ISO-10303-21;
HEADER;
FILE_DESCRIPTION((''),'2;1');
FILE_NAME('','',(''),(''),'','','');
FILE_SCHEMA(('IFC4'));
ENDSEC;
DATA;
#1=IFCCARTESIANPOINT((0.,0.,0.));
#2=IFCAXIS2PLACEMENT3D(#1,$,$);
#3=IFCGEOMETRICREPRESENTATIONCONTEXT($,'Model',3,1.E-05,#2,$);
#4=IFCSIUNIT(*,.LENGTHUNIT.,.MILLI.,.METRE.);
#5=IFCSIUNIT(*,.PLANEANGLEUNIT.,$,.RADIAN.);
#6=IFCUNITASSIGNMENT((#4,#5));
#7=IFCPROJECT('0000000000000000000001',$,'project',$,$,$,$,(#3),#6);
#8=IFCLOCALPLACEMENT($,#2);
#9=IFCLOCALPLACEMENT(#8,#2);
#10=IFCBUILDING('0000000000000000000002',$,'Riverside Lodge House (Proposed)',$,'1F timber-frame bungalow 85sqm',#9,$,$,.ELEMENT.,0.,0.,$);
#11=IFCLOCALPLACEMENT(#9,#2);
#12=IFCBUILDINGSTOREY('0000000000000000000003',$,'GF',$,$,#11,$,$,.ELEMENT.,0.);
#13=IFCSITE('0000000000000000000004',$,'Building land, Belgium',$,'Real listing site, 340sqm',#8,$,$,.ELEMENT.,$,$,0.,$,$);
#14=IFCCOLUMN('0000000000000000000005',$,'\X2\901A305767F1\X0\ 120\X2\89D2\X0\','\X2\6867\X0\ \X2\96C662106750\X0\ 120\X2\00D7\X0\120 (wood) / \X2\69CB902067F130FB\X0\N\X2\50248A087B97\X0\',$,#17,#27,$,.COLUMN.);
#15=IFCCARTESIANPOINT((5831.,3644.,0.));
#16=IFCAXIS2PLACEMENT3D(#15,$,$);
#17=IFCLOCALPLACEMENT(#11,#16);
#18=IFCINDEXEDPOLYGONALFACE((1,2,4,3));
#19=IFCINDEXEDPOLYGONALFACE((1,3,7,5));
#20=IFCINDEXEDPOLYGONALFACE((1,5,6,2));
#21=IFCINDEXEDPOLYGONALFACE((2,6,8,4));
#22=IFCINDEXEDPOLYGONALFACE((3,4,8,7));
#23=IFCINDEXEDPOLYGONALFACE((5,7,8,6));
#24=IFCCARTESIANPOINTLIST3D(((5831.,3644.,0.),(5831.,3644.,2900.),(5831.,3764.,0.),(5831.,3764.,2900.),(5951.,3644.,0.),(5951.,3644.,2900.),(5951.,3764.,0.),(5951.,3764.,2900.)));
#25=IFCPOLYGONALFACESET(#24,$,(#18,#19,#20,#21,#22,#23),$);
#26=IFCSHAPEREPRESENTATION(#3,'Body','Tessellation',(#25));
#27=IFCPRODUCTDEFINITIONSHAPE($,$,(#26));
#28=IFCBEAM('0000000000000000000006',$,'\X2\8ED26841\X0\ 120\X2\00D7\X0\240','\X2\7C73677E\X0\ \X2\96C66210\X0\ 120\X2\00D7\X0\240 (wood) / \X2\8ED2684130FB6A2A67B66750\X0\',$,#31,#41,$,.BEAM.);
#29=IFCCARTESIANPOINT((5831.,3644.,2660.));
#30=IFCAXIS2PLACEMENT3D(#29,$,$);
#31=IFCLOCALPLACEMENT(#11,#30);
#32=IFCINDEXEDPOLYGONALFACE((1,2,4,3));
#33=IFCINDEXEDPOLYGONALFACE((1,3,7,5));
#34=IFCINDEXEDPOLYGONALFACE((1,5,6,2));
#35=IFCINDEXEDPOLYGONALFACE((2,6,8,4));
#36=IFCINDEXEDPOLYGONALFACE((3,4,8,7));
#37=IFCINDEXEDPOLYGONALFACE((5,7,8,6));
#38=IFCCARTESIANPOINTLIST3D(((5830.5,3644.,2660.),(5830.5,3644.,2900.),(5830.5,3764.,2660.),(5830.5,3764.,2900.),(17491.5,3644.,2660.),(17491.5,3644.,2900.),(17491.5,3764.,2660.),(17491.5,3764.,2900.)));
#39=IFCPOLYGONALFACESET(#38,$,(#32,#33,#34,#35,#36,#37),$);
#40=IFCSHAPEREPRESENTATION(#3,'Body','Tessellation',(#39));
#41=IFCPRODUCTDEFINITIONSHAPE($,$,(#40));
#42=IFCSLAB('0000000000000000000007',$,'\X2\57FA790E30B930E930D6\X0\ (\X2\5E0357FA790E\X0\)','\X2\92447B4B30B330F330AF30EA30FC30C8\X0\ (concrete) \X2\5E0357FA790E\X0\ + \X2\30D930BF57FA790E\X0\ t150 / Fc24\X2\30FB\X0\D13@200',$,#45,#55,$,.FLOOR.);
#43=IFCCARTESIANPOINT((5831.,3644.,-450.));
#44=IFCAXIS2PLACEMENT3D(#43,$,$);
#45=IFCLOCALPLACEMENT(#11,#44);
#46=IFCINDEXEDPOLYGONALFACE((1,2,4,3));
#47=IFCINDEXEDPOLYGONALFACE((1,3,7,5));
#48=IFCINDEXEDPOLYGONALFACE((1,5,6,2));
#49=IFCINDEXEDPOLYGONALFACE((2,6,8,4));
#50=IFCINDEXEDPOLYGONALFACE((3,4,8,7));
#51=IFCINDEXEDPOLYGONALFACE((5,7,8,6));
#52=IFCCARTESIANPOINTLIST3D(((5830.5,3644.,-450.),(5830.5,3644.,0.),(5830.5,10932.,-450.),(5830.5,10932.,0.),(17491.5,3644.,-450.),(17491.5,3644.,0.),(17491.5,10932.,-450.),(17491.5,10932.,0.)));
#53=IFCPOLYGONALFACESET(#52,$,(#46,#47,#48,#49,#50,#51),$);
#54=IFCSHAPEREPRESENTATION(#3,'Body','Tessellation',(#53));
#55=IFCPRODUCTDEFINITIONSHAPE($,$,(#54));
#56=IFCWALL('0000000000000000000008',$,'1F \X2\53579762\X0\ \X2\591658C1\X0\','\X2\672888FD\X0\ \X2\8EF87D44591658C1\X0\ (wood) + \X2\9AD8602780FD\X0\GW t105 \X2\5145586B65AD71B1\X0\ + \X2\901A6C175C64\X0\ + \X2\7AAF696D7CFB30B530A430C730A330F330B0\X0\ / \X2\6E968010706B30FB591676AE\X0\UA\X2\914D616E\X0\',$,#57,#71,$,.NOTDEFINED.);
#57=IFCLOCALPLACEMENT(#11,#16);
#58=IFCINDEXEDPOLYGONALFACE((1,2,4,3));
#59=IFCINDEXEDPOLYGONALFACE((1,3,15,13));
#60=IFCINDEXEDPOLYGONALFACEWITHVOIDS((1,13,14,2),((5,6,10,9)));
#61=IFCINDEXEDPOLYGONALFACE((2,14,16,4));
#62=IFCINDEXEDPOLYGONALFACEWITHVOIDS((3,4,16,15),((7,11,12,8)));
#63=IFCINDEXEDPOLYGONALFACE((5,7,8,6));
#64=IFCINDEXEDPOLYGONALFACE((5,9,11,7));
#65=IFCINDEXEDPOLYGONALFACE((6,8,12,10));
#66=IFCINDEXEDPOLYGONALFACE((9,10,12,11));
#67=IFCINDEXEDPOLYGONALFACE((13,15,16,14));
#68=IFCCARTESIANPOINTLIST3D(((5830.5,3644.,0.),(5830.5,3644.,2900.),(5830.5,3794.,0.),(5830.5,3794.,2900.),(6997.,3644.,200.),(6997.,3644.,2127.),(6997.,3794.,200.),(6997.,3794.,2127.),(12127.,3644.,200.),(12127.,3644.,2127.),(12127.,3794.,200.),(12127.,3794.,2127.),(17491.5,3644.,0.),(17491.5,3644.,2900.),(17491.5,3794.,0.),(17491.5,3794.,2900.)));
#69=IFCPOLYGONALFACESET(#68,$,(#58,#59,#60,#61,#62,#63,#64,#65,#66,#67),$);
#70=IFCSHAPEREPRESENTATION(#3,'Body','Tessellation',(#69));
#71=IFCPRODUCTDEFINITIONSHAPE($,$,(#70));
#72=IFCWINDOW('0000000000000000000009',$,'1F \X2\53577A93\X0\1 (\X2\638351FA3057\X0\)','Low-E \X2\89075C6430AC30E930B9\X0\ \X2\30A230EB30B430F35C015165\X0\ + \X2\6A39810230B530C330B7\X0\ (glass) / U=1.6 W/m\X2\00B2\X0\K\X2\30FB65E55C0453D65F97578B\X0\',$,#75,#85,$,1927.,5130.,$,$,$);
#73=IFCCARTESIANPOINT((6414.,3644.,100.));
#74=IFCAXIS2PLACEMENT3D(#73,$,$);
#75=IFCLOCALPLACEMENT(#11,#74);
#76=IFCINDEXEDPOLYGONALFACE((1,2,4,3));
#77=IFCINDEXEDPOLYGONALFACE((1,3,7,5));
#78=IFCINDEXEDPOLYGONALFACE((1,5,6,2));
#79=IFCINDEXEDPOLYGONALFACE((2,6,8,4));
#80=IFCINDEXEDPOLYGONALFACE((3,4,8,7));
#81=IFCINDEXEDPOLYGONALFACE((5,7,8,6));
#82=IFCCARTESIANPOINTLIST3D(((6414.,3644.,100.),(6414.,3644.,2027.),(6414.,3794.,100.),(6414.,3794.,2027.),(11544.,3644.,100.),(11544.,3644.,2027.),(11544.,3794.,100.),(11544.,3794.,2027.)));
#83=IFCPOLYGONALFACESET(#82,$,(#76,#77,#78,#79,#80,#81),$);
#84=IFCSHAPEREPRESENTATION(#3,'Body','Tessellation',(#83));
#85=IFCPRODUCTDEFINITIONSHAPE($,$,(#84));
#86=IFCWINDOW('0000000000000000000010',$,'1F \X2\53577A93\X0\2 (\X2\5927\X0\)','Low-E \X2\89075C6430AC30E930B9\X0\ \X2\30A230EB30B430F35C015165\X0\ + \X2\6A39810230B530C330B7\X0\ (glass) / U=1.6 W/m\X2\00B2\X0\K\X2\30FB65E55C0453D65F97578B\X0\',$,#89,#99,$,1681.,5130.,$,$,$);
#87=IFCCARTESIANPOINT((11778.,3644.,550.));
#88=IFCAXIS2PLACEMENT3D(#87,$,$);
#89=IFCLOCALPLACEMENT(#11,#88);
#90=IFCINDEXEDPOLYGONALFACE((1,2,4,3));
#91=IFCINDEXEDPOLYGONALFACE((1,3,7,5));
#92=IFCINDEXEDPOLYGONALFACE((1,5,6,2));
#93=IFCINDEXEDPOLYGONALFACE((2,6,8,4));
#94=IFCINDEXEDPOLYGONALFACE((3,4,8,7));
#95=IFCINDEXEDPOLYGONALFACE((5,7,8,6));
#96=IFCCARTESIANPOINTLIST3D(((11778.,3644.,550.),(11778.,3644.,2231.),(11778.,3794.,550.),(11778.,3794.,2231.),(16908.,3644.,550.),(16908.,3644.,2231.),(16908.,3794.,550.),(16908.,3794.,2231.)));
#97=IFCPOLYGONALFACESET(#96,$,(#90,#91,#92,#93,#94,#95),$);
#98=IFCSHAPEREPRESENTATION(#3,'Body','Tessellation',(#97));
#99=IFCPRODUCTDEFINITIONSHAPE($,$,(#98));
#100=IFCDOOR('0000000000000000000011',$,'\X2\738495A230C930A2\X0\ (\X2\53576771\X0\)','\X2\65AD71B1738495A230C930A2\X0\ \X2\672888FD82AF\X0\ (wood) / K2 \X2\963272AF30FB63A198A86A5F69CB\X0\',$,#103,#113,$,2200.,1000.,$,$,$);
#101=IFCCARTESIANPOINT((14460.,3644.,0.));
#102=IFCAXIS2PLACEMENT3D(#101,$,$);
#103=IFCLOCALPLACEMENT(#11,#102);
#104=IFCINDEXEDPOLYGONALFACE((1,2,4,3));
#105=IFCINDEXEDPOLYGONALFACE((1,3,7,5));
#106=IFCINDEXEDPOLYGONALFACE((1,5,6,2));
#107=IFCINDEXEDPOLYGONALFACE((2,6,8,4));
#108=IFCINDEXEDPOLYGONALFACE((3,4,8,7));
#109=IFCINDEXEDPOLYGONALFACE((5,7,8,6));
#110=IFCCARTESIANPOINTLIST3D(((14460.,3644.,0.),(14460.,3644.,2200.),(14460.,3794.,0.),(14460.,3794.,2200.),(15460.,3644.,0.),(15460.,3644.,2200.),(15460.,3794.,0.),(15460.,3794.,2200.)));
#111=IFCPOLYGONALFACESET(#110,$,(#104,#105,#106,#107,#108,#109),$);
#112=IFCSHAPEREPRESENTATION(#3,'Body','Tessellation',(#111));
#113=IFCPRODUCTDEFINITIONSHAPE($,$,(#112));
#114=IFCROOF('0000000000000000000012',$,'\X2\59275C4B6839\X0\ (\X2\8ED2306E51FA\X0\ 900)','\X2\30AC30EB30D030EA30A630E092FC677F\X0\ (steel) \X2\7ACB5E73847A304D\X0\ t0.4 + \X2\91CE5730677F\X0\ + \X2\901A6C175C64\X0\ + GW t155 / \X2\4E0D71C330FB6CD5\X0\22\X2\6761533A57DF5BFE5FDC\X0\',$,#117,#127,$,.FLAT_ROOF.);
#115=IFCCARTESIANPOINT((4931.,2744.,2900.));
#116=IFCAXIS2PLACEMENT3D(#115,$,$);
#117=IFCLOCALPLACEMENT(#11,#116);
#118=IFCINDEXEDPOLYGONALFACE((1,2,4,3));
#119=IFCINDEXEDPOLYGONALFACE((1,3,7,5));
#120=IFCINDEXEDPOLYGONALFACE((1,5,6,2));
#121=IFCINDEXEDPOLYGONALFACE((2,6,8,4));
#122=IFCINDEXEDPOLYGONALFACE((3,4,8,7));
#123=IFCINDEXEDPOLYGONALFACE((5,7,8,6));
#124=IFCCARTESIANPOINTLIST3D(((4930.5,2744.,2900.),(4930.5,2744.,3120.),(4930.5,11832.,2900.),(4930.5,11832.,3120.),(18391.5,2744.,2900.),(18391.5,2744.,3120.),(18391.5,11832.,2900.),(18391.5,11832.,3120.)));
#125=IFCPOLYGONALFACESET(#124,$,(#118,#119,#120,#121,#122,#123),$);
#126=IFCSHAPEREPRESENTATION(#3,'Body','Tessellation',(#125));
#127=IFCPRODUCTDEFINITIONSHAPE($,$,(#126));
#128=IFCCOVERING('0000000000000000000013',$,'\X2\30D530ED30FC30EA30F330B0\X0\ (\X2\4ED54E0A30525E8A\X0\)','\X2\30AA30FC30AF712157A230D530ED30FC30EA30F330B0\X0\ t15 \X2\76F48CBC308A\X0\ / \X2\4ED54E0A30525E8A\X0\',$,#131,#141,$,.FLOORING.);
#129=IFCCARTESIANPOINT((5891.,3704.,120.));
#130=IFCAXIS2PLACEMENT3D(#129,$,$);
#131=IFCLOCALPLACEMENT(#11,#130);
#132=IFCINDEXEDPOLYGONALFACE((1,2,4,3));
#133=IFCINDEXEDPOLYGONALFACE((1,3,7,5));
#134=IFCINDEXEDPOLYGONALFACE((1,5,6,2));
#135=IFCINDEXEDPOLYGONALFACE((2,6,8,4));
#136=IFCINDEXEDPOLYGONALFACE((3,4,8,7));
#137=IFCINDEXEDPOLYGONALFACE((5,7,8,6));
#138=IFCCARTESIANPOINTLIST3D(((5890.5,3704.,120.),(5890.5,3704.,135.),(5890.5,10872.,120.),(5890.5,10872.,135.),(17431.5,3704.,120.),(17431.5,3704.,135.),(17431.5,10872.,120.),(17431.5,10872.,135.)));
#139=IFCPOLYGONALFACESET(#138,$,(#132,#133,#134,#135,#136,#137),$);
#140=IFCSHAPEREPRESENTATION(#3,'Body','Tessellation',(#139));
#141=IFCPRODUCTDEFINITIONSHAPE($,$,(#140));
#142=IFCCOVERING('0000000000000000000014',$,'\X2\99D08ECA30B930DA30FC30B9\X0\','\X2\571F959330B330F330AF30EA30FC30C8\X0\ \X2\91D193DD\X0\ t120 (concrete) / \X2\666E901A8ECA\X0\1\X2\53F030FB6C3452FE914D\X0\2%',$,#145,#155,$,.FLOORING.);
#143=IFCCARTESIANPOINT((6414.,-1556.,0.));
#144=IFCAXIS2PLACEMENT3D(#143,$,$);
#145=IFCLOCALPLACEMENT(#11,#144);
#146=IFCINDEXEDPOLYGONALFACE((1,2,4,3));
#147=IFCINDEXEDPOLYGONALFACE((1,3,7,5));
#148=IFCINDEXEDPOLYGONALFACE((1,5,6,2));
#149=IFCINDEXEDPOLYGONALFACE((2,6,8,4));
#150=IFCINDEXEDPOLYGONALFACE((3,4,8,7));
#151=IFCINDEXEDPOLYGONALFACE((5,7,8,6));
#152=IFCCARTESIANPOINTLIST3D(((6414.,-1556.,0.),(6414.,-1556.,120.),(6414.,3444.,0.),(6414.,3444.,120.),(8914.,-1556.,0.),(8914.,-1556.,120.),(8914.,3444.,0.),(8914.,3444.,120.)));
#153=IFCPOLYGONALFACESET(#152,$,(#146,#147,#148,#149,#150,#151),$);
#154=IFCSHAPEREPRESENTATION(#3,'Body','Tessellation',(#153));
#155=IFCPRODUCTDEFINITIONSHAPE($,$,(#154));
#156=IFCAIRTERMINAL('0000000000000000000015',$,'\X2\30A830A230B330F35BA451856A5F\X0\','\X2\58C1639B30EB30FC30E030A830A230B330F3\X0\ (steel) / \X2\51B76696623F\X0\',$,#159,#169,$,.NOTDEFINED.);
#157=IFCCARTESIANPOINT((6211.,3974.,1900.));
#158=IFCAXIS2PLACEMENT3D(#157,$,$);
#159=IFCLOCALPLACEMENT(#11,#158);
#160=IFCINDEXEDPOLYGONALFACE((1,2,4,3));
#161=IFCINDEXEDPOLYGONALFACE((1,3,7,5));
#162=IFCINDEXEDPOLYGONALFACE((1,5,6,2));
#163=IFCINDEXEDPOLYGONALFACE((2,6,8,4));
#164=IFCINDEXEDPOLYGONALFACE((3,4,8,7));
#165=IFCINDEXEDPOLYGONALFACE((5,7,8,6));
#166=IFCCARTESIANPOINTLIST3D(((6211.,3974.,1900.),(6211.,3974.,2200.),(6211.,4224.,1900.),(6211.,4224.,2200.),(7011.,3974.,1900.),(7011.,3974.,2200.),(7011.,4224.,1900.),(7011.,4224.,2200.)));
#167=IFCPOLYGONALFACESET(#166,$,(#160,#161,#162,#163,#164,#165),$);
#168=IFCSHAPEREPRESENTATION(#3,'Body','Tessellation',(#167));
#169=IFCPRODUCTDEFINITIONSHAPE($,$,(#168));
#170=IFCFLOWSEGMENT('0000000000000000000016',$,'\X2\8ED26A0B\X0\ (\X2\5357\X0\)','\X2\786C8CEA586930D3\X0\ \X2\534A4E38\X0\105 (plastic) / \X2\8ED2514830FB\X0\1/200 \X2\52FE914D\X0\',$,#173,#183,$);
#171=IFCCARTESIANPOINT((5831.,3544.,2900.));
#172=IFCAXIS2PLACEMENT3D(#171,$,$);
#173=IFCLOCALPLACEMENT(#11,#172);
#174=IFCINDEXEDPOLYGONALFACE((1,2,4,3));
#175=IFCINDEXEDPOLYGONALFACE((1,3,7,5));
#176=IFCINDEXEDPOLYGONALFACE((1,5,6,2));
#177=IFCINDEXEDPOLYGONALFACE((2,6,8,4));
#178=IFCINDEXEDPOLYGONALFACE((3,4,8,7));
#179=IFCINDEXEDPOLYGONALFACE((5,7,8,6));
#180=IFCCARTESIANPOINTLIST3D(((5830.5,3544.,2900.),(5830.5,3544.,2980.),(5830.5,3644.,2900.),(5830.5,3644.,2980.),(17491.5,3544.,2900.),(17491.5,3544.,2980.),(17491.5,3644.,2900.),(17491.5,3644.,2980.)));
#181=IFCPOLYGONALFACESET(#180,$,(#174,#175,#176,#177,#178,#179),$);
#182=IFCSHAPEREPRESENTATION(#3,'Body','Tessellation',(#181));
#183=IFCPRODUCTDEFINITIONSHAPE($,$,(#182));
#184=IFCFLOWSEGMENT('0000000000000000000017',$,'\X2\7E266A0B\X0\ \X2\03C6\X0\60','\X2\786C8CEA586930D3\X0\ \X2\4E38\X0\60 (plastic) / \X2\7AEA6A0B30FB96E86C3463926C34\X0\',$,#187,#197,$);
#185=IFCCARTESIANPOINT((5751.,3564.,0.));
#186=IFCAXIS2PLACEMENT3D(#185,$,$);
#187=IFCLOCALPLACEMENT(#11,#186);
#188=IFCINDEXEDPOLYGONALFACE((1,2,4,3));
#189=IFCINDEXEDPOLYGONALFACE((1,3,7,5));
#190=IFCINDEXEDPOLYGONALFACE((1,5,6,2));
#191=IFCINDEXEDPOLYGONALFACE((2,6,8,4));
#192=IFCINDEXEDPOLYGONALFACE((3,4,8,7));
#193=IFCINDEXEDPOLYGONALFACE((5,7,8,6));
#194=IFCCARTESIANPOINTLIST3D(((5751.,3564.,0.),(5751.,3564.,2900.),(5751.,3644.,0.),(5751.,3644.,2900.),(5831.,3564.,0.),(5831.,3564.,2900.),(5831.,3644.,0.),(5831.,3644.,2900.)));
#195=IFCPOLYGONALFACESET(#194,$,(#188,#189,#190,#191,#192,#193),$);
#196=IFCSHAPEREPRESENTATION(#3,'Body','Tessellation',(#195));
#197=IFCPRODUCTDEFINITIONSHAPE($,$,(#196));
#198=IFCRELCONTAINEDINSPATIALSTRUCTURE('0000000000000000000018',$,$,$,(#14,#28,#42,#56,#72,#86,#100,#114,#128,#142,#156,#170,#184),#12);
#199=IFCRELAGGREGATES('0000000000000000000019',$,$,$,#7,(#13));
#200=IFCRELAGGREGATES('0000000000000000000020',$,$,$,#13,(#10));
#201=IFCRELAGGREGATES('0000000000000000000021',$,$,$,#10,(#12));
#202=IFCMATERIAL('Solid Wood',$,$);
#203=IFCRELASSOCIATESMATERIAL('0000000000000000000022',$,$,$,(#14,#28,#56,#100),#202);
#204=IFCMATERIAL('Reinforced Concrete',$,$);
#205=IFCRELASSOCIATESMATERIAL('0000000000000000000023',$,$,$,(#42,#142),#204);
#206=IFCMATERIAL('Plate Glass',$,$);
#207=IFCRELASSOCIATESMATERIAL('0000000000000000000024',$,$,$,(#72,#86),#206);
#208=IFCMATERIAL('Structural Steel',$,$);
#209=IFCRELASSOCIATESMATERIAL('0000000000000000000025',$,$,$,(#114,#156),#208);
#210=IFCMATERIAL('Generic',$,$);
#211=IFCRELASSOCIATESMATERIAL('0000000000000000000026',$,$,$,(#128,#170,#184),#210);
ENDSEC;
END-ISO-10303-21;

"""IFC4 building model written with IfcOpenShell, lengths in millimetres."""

from ifc_helpers import new_model, si_unit, frame, frame_2d, origin, place, context, project, spatial, rectangle, extrude, material, element, fill, save


model = new_model("IFC4")

# Units and contexts
model_context = context("Model", 3, precision=1e-05, world=origin())
ifc_project = project(units=[si_unit("LENGTHUNIT", "METRE", prefix="MILLI"), si_unit("PLANEANGLEUNIT", "RADIAN")], contexts=[model_context])

# Site, building, storey
site_placement = place(None, origin())
site = spatial("IfcSite", under=ifc_project, at=site_placement, Name="Building land, Belgium", ObjectType="Real listing site, 340sqm", CompositionType="ELEMENT", RefElevation=0.0)
building_placement = place(site_placement, origin())
building = spatial("IfcBuilding", under=site, at=building_placement, Name="Riverside Lodge House (Proposed)", ObjectType="1F timber-frame bungalow 85sqm", CompositionType="ELEMENT", ElevationOfRefHeight=0.0, ElevationOfTerrain=0.0)
storey_placement = place(building_placement, origin())
storey = spatial("IfcBuildingStorey", under=building, at=storey_placement, Name="GF", CompositionType="ELEMENT", Elevation=0.0)

# Column
ifc_material_1 = material(Name="Solid Wood")
column_1_placement = place(storey_placement, frame((5831.0, 3644.0, 0.0)))
element("IfcColumn", 1, at=column_1_placement, inside=storey, material=ifc_material_1, Name="通し柱 120角", Description="桧 集成材 120×120 (wood) / 構造柱・N値計算", PredefinedType="COLUMN", context=model_context, shape_type="SweptSolid", body=[
    extrude(rectangle(XDim=120.0, YDim=120.0, at=frame_2d((60.0, 60.0))), frame((5831.0, 3644.0, 0.0)), (0.0, 0.0, 1.0), 2900.0),
])

# Beam
beam_1_placement = place(storey_placement, frame((5831.0, 3644.0, 2660.0)))
element("IfcBeam", 2, at=beam_1_placement, inside=storey, material=ifc_material_1, Name="軒桁 120×240", Description="米松 集成 120×240 (wood) / 軒桁・横架材", PredefinedType="BEAM", context=model_context, shape_type="SweptSolid", body=[
    extrude(rectangle(XDim=11661.0, YDim=120.0, at=frame_2d((5830.0, 60.0))), frame((5831.0, 3644.0, 2660.0)), (0.0, 0.0, 1.0), 240.0),
])

# Slab
ifc_material_2 = material(Name="Reinforced Concrete")
slab_1_placement = place(storey_placement, frame((5831.0, 3644.0, -450.0)))
element("IfcSlab", 3, at=slab_1_placement, inside=storey, material=ifc_material_2, Name="基礎スラブ (布基礎)", Description="鉄筋コンクリート (concrete) 布基礎 + ベタ基礎 t150 / Fc24・D13@200", PredefinedType="FLOOR", context=model_context, shape_type="SweptSolid", body=[
    extrude(rectangle(XDim=11661.0, YDim=7288.0, at=frame_2d((5830.0, 3644.0))), frame((5831.0, 3644.0, -450.0)), (0.0, 0.0, 1.0), 450.0),
])

# Wall, openings, windows, door
wall_1_placement = place(storey_placement, frame((5831.0, 3644.0, 0.0)))
wall_1 = element("IfcWall", 4, at=wall_1_placement, inside=storey, material=ifc_material_1, Name="1F 南面 外壁", Description="木製 軸組外壁 (wood) + 高性能GW t105 充填断熱 + 通気層 + 窯業系サイディング / 準耐火・外皮UA配慮", PredefinedType="NOTDEFINED", context=model_context, shape_type="SweptSolid", body=[
    extrude(rectangle(XDim=11661.0, YDim=150.0, at=frame_2d((5830.0, 75.0))), frame((5831.0, 3644.0, 0.0)), (0.0, 0.0, 1.0), 2900.0),
])
opening_1_placement = place(storey_placement, frame((6414.0, 3644.0, 100.0)))
opening_1 = element("IfcOpeningElement", 5, at=opening_1_placement, cuts=wall_1, PredefinedType="NOTDEFINED", context=model_context, shape_type="SweptSolid", body=[
    extrude(rectangle(XDim=5130.0, YDim=150.0, at=frame_2d((2565.0, 75.0))), frame((6414.0, 3644.0, 100.0)), (0.0, 0.0, 1.0), 1927.0),
])
opening_2_placement = place(storey_placement, frame((11778.0, 3644.0, 550.0)))
opening_2 = element("IfcOpeningElement", 6, at=opening_2_placement, cuts=wall_1, PredefinedType="NOTDEFINED", context=model_context, shape_type="SweptSolid", body=[
    extrude(rectangle(XDim=5130.0, YDim=150.0, at=frame_2d((2565.0, 75.0))), frame((11778.0, 3644.0, 550.0)), (0.0, 0.0, 1.0), 1681.0),
])
opening_3_placement = place(storey_placement, frame((14460.0, 3644.0, 0.0)))
opening_3 = element("IfcOpeningElement", 7, at=opening_3_placement, cuts=wall_1, PredefinedType="NOTDEFINED", context=model_context, shape_type="SweptSolid", body=[
    extrude(rectangle(XDim=1000.0, YDim=150.0, at=frame_2d((500.0, 75.0))), frame((14460.0, 3644.0, 0.0)), (0.0, 0.0, 1.0), 2200.0),
])
ifc_material_3 = material(Name="Plate Glass")
window_1_placement = place(storey_placement, frame((6414.0, 3644.0, 100.0)))
window_1 = element("IfcWindow", 8, at=window_1_placement, inside=storey, material=ifc_material_3, Name="1F 南窓1 (掃出し)", Description="Low-E 複層ガラス アルゴン封入 + 樹脂サッシ (glass) / U=1.6 W/m²K・日射取得型", OverallHeight=1927.0, OverallWidth=5130.0, context=model_context, shape_type="SweptSolid", body=[
    extrude(rectangle(XDim=5130.0, YDim=150.0, at=frame_2d((2565.0, 75.0))), frame((6414.0, 3644.0, 100.0)), (0.0, 0.0, 1.0), 1927.0),
])
fill(opening_1, window_1)
window_2_placement = place(storey_placement, frame((11778.0, 3644.0, 550.0)))
window_2 = element("IfcWindow", 9, at=window_2_placement, inside=storey, material=ifc_material_3, Name="1F 南窓2 (大)", Description="Low-E 複層ガラス アルゴン封入 + 樹脂サッシ (glass) / U=1.6 W/m²K・日射取得型", OverallHeight=1681.0, OverallWidth=5130.0, context=model_context, shape_type="SweptSolid", body=[
    extrude(rectangle(XDim=5130.0, YDim=150.0, at=frame_2d((2565.0, 75.0))), frame((11778.0, 3644.0, 550.0)), (0.0, 0.0, 1.0), 1681.0),
])
fill(opening_2, window_2)
door_placement = place(storey_placement, frame((14460.0, 3644.0, 0.0)))
door = element("IfcDoor", 10, at=door_placement, inside=storey, material=ifc_material_1, Name="玄関ドア (南東)", Description="断熱玄関ドア 木製芯 (wood) / K2 防犯・採風機構", OverallHeight=2200.0, OverallWidth=1000.0, context=model_context, shape_type="SweptSolid", body=[
    extrude(rectangle(XDim=1000.0, YDim=150.0, at=frame_2d((500.0, 75.0))), frame((14460.0, 3644.0, 0.0)), (0.0, 0.0, 1.0), 2200.0),
])
fill(opening_3, door)

# Roof
ifc_material_4 = material(Name="Structural Steel")
roof_placement = place(storey_placement, frame((4931.0, 2744.0, 2900.0)))
element("IfcRoof", 11, at=roof_placement, inside=storey, material=ifc_material_4, Name="大屋根 (軒の出 900)", Description="ガルバリウム鋼板 (steel) 立平葺き t0.4 + 野地板 + 通気層 + GW t155 / 不燃・法22条区域対応", PredefinedType="FLAT_ROOF", context=model_context, shape_type="SweptSolid", body=[
    extrude(rectangle(XDim=13461.0, YDim=9088.0, at=frame_2d((6730.0, 4544.0))), frame((4931.0, 2744.0, 2900.0)), (0.0, 0.0, 1.0), 220.0),
])

# Coverings
ifc_material_5 = material(Name="Generic")
covering_1_placement = place(storey_placement, frame((5891.0, 3704.0, 120.0)))
element("IfcCovering", 12, at=covering_1_placement, inside=storey, material=ifc_material_5, Name="フローリング (仕上げ床)", Description="オーク無垢フローリング t15 直貼り / 仕上げ床", PredefinedType="FLOORING", context=model_context, shape_type="SweptSolid", body=[
    extrude(rectangle(XDim=11541.0, YDim=7168.0, at=frame_2d((5770.0, 3584.0))), frame((5891.0, 3704.0, 120.0)), (0.0, 0.0, 1.0), 15.0),
])
covering_2_placement = place(storey_placement, frame((6414.0, -1556.0, 0.0)))
element("IfcCovering", 13, at=covering_2_placement, inside=storey, material=ifc_material_2, Name="駐車スペース", Description="土間コンクリート 金鏝 t120 (concrete) / 普通車1台・水勾配2%", PredefinedType="FLOORING", context=model_context, shape_type="SweptSolid", body=[
    extrude(rectangle(XDim=2500.0, YDim=5000.0, at=frame_2d((1250.0, 2500.0))), frame((6414.0, -1556.0, 0.0)), (0.0, 0.0, 1.0), 120.0),
])

# Air terminal
air_terminal_placement = place(storey_placement, frame((6211.0, 3974.0, 1900.0)))
element("IfcAirTerminal", 14, at=air_terminal_placement, inside=storey, material=ifc_material_4, Name="エアコン室内機", Description="壁掛ルームエアコン (steel) / 冷暖房", PredefinedType="NOTDEFINED", context=model_context, shape_type="SweptSolid", body=[
    extrude(rectangle(XDim=800.0, YDim=250.0, at=frame_2d((400.0, 125.0))), frame((6211.0, 3974.0, 1900.0)), (0.0, 0.0, 1.0), 300.0),
])

# Flow segments
flow_segment_1_placement = place(storey_placement, frame((5831.0, 3544.0, 2900.0)))
element("IfcFlowSegment", 15, at=flow_segment_1_placement, inside=storey, material=ifc_material_5, Name="軒樋 (南)", Description="硬質塩ビ 半丸105 (plastic) / 軒先・1/200 勾配", context=model_context, shape_type="SweptSolid", body=[
    extrude(rectangle(XDim=11661.0, YDim=100.0, at=frame_2d((5830.0, 50.0))), frame((5831.0, 3544.0, 2900.0)), (0.0, 0.0, 1.0), 80.0),
])
flow_segment_2_placement = place(storey_placement, frame((5751.0, 3564.0, 0.0)))
element("IfcFlowSegment", 16, at=flow_segment_2_placement, inside=storey, material=ifc_material_5, Name="縦樋 φ60", Description="硬質塩ビ 丸60 (plastic) / 竪樋・雨水排水", context=model_context, shape_type="SweptSolid", body=[
    extrude(rectangle(XDim=80.0, YDim=80.0, at=frame_2d((40.0, 40.0))), frame((5751.0, 3564.0, 0.0)), (0.0, 0.0, 1.0), 2900.0),
])

save(model, "model.ifc")
